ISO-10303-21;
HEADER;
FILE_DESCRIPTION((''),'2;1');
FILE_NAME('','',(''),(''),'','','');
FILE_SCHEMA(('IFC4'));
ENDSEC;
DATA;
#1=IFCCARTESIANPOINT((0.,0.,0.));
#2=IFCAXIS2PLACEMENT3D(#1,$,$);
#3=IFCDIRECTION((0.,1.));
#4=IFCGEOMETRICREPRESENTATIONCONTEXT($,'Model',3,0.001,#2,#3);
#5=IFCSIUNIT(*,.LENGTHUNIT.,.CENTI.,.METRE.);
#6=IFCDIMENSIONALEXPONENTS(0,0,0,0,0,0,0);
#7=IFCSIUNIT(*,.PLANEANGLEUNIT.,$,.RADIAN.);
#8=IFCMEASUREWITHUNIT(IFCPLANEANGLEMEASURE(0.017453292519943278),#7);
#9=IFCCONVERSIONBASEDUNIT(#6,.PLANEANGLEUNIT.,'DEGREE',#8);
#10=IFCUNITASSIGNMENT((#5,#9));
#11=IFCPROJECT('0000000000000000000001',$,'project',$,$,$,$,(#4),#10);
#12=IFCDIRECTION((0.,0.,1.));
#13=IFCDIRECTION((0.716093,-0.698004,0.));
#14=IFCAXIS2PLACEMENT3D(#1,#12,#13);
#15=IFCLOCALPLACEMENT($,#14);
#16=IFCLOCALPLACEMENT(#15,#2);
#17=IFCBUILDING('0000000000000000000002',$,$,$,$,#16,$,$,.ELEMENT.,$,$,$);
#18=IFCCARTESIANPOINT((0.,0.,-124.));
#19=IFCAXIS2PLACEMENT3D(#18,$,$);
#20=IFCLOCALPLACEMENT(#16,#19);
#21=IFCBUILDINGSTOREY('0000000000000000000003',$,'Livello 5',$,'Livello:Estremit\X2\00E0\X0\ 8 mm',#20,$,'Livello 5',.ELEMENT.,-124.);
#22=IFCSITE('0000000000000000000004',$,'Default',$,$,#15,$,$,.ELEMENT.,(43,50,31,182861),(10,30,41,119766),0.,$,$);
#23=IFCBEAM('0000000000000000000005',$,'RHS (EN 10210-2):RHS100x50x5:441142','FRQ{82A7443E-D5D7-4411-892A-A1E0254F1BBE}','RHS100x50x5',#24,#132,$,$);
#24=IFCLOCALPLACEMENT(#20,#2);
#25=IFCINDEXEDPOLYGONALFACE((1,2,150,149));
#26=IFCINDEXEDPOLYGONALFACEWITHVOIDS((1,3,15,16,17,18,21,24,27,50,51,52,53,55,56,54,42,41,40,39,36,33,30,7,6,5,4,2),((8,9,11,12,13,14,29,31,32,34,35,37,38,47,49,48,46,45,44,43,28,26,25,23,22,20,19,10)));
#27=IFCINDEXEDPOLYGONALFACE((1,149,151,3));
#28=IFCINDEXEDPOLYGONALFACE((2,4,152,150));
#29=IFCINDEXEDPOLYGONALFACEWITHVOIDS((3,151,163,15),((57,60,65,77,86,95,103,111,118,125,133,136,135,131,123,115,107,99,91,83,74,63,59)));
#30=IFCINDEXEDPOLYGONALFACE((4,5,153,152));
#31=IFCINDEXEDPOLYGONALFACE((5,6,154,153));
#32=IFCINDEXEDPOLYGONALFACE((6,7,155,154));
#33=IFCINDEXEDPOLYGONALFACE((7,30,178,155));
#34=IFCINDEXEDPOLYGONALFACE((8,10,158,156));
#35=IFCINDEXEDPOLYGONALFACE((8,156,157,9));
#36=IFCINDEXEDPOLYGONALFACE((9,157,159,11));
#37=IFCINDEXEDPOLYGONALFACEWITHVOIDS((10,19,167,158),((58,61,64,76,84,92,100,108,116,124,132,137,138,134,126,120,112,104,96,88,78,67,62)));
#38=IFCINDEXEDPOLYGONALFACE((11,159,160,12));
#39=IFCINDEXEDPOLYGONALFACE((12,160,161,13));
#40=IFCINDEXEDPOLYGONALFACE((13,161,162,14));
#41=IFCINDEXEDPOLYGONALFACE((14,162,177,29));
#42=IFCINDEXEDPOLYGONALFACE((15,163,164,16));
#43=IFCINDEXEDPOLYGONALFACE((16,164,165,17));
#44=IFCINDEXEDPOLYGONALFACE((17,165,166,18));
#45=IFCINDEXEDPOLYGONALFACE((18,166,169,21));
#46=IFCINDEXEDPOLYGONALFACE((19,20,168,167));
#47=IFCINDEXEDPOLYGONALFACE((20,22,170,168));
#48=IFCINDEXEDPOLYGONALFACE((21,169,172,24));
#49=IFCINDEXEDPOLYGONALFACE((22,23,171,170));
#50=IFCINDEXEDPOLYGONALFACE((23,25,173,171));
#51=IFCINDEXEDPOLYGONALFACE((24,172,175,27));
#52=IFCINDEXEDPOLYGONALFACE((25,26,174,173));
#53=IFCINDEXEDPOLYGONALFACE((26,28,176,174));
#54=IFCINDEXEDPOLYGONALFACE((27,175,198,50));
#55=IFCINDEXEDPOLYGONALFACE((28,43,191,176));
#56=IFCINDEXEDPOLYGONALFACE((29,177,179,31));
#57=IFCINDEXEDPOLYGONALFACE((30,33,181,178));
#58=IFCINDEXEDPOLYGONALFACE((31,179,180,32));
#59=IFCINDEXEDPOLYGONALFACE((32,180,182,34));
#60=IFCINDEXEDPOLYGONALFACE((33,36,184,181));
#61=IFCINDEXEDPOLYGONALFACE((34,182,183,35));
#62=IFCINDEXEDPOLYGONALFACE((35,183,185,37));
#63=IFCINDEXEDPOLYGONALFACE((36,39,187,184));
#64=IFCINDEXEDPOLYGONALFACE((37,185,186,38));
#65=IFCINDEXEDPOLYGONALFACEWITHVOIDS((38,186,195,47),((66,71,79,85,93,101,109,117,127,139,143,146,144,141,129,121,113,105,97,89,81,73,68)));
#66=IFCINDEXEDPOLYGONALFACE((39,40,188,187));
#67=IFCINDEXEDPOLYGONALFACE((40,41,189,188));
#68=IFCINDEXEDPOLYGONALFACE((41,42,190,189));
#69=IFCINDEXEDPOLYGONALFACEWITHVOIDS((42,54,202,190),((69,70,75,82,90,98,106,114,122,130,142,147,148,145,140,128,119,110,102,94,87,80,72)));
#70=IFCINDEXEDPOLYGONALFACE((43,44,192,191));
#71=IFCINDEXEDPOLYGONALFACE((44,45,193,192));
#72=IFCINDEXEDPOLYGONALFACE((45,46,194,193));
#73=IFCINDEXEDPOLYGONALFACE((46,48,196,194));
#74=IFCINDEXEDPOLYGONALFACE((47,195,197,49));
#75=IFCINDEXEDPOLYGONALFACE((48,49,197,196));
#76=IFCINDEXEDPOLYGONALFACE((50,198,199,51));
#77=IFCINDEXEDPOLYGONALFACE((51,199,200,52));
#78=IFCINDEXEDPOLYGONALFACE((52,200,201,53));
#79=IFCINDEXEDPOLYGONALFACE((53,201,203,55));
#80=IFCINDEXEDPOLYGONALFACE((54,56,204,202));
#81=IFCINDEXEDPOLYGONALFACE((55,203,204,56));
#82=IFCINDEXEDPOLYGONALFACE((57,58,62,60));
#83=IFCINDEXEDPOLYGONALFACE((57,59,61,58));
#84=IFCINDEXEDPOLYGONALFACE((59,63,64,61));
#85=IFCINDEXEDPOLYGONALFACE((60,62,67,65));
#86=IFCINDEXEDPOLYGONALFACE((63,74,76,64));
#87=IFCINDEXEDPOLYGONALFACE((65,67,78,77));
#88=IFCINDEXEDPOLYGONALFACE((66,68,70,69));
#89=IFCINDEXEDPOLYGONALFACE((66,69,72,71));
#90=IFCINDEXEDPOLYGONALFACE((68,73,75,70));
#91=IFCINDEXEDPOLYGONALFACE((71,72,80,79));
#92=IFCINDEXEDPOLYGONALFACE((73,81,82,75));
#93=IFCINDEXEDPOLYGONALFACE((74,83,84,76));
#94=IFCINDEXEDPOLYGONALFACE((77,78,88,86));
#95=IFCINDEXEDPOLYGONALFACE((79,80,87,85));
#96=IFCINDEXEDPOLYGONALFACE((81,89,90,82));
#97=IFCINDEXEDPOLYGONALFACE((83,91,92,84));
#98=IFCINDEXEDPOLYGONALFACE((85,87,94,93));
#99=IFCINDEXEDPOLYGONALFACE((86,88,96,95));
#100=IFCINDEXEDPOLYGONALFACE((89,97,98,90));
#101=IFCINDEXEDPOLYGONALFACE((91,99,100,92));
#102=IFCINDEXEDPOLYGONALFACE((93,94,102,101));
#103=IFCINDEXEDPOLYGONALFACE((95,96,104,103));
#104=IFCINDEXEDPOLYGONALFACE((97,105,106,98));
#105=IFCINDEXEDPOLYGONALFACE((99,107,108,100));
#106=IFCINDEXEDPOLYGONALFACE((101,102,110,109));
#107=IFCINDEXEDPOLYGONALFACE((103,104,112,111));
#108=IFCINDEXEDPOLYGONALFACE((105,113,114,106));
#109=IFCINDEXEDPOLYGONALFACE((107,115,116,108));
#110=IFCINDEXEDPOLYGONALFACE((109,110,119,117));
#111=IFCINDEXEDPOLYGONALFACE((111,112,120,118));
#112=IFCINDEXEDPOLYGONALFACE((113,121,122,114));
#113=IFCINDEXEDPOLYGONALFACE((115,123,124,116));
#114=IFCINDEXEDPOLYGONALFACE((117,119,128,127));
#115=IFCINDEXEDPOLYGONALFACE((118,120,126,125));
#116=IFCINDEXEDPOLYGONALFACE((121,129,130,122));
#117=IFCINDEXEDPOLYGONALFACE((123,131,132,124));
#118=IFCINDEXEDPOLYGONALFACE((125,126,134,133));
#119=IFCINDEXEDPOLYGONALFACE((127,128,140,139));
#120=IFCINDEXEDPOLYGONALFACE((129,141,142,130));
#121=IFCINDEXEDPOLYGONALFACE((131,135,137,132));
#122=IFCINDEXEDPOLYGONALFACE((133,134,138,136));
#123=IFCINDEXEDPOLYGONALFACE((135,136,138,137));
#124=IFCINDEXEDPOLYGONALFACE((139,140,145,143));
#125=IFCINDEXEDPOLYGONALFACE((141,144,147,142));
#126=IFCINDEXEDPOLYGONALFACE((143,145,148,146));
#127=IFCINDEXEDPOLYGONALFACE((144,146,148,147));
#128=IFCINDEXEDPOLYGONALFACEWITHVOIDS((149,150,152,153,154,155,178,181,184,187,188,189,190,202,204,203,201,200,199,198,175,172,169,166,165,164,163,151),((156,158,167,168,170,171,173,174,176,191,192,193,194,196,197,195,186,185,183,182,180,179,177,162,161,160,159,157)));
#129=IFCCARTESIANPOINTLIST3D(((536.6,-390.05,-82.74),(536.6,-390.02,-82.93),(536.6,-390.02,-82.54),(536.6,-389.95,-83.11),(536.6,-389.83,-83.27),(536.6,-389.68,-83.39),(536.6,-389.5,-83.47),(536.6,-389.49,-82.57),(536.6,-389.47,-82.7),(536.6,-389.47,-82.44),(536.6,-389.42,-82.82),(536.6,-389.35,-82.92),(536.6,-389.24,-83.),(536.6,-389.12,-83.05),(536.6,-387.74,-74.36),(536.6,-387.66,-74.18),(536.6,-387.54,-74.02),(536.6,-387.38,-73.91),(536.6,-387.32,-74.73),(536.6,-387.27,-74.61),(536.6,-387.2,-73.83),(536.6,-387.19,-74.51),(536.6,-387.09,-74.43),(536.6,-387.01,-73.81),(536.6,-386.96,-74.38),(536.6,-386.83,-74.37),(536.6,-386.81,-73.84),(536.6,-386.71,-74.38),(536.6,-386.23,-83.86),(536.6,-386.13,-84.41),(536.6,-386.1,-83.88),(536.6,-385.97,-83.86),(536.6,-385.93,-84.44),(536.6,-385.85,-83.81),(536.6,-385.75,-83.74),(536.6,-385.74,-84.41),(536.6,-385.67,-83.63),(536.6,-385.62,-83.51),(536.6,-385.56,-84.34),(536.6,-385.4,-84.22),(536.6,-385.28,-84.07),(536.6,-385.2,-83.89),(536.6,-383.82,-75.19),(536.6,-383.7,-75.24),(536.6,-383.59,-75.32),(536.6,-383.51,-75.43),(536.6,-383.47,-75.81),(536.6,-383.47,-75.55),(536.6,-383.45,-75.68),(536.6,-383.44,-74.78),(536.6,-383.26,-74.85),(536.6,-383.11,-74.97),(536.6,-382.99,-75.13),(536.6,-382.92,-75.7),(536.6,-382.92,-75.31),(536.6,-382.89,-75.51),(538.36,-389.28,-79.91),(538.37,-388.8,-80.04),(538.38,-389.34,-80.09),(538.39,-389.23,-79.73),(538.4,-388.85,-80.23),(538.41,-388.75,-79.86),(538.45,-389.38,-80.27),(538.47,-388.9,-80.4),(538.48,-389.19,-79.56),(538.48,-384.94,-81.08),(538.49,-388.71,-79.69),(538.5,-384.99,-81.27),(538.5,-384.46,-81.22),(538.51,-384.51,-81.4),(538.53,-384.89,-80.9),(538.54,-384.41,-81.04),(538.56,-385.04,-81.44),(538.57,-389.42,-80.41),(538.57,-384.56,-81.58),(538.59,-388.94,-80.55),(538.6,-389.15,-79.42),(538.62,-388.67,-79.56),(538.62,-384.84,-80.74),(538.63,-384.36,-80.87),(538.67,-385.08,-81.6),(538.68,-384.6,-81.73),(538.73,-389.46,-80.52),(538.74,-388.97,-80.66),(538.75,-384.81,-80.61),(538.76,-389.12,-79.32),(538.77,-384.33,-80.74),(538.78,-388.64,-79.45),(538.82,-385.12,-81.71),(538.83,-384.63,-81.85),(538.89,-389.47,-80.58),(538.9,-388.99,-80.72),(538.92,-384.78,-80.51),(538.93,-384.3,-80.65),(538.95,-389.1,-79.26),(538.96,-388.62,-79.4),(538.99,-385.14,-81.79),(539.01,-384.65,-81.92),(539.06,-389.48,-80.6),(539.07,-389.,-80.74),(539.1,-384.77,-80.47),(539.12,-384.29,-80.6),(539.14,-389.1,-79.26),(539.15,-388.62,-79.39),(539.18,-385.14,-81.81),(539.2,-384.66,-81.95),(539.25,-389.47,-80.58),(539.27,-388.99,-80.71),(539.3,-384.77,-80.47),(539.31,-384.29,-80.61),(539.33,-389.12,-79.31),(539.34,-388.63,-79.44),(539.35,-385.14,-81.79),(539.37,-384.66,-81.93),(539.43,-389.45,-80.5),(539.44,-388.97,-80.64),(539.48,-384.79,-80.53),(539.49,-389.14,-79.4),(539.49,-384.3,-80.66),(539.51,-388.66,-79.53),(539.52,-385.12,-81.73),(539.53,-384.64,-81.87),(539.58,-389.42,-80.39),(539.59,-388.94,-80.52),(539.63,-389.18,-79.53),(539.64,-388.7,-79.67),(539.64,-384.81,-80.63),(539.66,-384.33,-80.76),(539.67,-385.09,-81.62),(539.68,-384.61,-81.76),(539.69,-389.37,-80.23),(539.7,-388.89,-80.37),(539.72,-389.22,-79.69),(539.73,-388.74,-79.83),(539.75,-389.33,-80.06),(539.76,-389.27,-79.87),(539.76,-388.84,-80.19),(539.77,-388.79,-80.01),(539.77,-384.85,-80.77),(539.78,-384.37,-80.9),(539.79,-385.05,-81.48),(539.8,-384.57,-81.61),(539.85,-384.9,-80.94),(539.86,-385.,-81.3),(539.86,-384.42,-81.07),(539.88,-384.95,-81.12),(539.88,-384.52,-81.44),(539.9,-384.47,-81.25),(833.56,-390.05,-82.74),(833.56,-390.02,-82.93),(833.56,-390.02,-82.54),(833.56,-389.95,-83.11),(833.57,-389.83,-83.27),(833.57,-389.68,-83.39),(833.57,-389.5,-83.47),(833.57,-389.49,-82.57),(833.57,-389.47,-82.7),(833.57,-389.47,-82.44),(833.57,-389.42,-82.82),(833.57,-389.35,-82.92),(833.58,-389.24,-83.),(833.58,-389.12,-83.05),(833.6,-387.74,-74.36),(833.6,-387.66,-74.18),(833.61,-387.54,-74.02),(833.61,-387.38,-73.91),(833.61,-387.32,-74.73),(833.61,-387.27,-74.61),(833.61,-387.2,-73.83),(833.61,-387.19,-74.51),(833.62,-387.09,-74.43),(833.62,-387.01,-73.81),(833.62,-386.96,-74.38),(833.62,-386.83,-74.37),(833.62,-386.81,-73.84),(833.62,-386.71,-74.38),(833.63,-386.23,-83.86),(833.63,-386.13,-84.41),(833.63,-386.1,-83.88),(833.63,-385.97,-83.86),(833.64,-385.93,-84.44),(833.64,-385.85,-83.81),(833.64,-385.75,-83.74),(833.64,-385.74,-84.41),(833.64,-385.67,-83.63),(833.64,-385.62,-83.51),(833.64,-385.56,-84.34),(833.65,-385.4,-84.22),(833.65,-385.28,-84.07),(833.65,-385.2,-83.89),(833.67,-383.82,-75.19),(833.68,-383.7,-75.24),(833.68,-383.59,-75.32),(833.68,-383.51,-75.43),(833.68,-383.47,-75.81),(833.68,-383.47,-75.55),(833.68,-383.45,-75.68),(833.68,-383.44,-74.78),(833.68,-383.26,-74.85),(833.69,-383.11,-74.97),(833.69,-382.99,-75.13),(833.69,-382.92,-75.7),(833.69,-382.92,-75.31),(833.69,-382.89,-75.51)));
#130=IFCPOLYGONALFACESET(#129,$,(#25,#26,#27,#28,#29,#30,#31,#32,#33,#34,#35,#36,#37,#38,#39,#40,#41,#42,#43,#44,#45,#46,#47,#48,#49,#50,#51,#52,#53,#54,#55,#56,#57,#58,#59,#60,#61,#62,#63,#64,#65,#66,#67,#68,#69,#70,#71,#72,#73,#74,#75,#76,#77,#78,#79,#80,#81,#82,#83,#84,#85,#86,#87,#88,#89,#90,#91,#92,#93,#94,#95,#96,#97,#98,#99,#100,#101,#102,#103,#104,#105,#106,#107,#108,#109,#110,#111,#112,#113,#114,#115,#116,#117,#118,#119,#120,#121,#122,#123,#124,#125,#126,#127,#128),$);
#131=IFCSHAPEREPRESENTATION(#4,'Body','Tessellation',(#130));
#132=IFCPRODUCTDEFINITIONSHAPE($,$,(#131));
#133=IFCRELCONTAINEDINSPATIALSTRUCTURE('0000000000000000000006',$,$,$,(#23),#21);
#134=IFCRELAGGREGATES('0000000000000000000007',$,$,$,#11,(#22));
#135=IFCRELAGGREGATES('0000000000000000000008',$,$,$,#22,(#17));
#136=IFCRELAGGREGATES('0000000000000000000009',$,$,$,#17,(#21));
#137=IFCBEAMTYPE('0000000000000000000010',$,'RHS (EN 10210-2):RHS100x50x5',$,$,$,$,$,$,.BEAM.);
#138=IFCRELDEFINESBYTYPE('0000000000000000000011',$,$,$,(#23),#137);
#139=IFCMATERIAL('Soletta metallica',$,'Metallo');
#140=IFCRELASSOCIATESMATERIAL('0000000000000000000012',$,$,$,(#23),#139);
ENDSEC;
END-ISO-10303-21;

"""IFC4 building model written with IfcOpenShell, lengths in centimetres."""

from ifc_helpers import new_model, entity, si_unit, converted_unit, direction, frame, frame_2d, origin, origin_2d, place, context, project, spatial, hollow_rectangle, circle, extrude, clip, halfspace, material, type_object, element, save


model = new_model("IFC4")

# Units and contexts
model_context = context("Model", 3, precision=0.001, world=origin(), true_north=direction((0.0, 1.0)))
ifc_project = project(units=[si_unit("LENGTHUNIT", "METRE", prefix="CENTI"), converted_unit("PLANEANGLEUNIT", "DEGREE", entity("IfcPlaneAngleMeasure", 0.017453292519943278), si_unit("PLANEANGLEUNIT", "RADIAN"), dimensions=[0, 0, 0, 0, 0, 0, 0])], contexts=[model_context])

# Site, building, storey
site_placement = place(None, frame((0.0, 0.0, 0.0), z_axis=(0.0, 0.0, 1.0), x_axis=(0.716093, -0.698004, 0.0)))
site = spatial("IfcSite", under=ifc_project, at=site_placement, Name="Default", CompositionType="ELEMENT", RefLatitude=(43, 50, 31, 182861), RefLongitude=(10, 30, 41, 119766), RefElevation=0.0)
building_placement = place(site_placement, origin())
building = spatial("IfcBuilding", under=site, at=building_placement, CompositionType="ELEMENT")
storey_placement = place(building_placement, frame((0.0, 0.0, -124.0)))
storey = spatial("IfcBuildingStorey", under=building, at=storey_placement, Name="Livello 5", ObjectType="Livello:Estremità 8 mm", LongName="Livello 5", CompositionType="ELEMENT", Elevation=-124.0)

# Beam, openings
ifc_material_1 = material(Name="Soletta metallica", Category="Metallo")
beam_type_1 = type_object("IfcBeamType", Name="RHS (EN 10210-2):RHS100x50x5", PredefinedType="BEAM")
beam_1_placement = place(storey_placement, frame((852.31, -386.47, -79.12), z_axis=(1.0, 0.0, 0.0), x_axis=(0.0, 0.963256, -0.268584)))
beam_1 = element("IfcBeam", 1, at=beam_1_placement, inside=storey, type_object=beam_type_1, material=ifc_material_1, Name="RHS (EN 10210-2):RHS100x50x5:441142", Description="FRQ{82A7443E-D5D7-4411-892A-A1E0254F1BBE}", ObjectType="RHS100x50x5", context=model_context, shape_type="Clipping", body=[
    clip(extrude(hollow_rectangle(XDim=5.0, YDim=10.0, WallThickness=0.5, InnerFilletRadius=0.5, OuterFilletRadius=0.75, at=origin_2d()), origin(), (0.0, 0.0, -1.0), 315.71), halfspace(frame((303.34, 295.45, -12.09), z_axis=(0.0171, 0.004768, -0.999842), x_axis=(-0.963105, -0.268541, -0.017752)), True)),
])
opening_1_placement = place(beam_1_placement, frame((2.05, -1.5, -317.43), z_axis=(-0.999637, 0.000101, -0.026952), x_axis=(-0.000101, -1.0, 0.0)))
element("IfcOpeningElement", 2, at=opening_1_placement, cuts=beam_1, ObjectType="Opening", context=model_context, shape_type="SweptSolid", body=[
    extrude(circle(Radius=0.7, at=frame_2d((-0.01, -0.7), x_axis=(1.0, 0.0))), origin(), (0.0, 0.0, -1.0), 0.63),
])
opening_2_placement = place(beam_1_placement, frame((1.92, -1.54, -312.43), z_axis=(-0.999637, 0.000101, -0.026952), x_axis=(-0.000101, -1.0, 0.0)))
element("IfcOpeningElement", 3, at=opening_2_placement, cuts=beam_1, ObjectType="Opening", context=model_context, shape_type="SweptSolid", body=[
    extrude(circle(Radius=0.7, at=frame_2d((-0.01, -0.7), x_axis=(1.0, 0.0))), origin(), (0.0, 0.0, -1.0), 0.63),
])
opening_3_placement = place(beam_1_placement, frame((-2.45, -1.5, -317.55), z_axis=(-0.999637, 0.000101, -0.026952), x_axis=(-0.000101, -1.0, 0.0)))
element("IfcOpeningElement", 4, at=opening_3_placement, cuts=beam_1, ObjectType="Opening", context=model_context, shape_type="SweptSolid", body=[
    extrude(circle(Radius=0.7, at=frame_2d((-0.01, -0.7), x_axis=(1.0, 0.0))), origin(), (0.0, 0.0, -1.0), 0.63),
])
opening_4_placement = place(beam_1_placement, frame((-2.58, -1.54, -312.55), z_axis=(-0.999637, 0.000101, -0.026952), x_axis=(-0.000101, -1.0, 0.0)))
element("IfcOpeningElement", 5, at=opening_4_placement, cuts=beam_1, ObjectType="Opening", context=model_context, shape_type="SweptSolid", body=[
    extrude(circle(Radius=0.7, at=frame_2d((-0.01, -0.7), x_axis=(1.0, 0.0))), origin(), (0.0, 0.0, -1.0), 0.63),
])

save(model, "model.ifc")
